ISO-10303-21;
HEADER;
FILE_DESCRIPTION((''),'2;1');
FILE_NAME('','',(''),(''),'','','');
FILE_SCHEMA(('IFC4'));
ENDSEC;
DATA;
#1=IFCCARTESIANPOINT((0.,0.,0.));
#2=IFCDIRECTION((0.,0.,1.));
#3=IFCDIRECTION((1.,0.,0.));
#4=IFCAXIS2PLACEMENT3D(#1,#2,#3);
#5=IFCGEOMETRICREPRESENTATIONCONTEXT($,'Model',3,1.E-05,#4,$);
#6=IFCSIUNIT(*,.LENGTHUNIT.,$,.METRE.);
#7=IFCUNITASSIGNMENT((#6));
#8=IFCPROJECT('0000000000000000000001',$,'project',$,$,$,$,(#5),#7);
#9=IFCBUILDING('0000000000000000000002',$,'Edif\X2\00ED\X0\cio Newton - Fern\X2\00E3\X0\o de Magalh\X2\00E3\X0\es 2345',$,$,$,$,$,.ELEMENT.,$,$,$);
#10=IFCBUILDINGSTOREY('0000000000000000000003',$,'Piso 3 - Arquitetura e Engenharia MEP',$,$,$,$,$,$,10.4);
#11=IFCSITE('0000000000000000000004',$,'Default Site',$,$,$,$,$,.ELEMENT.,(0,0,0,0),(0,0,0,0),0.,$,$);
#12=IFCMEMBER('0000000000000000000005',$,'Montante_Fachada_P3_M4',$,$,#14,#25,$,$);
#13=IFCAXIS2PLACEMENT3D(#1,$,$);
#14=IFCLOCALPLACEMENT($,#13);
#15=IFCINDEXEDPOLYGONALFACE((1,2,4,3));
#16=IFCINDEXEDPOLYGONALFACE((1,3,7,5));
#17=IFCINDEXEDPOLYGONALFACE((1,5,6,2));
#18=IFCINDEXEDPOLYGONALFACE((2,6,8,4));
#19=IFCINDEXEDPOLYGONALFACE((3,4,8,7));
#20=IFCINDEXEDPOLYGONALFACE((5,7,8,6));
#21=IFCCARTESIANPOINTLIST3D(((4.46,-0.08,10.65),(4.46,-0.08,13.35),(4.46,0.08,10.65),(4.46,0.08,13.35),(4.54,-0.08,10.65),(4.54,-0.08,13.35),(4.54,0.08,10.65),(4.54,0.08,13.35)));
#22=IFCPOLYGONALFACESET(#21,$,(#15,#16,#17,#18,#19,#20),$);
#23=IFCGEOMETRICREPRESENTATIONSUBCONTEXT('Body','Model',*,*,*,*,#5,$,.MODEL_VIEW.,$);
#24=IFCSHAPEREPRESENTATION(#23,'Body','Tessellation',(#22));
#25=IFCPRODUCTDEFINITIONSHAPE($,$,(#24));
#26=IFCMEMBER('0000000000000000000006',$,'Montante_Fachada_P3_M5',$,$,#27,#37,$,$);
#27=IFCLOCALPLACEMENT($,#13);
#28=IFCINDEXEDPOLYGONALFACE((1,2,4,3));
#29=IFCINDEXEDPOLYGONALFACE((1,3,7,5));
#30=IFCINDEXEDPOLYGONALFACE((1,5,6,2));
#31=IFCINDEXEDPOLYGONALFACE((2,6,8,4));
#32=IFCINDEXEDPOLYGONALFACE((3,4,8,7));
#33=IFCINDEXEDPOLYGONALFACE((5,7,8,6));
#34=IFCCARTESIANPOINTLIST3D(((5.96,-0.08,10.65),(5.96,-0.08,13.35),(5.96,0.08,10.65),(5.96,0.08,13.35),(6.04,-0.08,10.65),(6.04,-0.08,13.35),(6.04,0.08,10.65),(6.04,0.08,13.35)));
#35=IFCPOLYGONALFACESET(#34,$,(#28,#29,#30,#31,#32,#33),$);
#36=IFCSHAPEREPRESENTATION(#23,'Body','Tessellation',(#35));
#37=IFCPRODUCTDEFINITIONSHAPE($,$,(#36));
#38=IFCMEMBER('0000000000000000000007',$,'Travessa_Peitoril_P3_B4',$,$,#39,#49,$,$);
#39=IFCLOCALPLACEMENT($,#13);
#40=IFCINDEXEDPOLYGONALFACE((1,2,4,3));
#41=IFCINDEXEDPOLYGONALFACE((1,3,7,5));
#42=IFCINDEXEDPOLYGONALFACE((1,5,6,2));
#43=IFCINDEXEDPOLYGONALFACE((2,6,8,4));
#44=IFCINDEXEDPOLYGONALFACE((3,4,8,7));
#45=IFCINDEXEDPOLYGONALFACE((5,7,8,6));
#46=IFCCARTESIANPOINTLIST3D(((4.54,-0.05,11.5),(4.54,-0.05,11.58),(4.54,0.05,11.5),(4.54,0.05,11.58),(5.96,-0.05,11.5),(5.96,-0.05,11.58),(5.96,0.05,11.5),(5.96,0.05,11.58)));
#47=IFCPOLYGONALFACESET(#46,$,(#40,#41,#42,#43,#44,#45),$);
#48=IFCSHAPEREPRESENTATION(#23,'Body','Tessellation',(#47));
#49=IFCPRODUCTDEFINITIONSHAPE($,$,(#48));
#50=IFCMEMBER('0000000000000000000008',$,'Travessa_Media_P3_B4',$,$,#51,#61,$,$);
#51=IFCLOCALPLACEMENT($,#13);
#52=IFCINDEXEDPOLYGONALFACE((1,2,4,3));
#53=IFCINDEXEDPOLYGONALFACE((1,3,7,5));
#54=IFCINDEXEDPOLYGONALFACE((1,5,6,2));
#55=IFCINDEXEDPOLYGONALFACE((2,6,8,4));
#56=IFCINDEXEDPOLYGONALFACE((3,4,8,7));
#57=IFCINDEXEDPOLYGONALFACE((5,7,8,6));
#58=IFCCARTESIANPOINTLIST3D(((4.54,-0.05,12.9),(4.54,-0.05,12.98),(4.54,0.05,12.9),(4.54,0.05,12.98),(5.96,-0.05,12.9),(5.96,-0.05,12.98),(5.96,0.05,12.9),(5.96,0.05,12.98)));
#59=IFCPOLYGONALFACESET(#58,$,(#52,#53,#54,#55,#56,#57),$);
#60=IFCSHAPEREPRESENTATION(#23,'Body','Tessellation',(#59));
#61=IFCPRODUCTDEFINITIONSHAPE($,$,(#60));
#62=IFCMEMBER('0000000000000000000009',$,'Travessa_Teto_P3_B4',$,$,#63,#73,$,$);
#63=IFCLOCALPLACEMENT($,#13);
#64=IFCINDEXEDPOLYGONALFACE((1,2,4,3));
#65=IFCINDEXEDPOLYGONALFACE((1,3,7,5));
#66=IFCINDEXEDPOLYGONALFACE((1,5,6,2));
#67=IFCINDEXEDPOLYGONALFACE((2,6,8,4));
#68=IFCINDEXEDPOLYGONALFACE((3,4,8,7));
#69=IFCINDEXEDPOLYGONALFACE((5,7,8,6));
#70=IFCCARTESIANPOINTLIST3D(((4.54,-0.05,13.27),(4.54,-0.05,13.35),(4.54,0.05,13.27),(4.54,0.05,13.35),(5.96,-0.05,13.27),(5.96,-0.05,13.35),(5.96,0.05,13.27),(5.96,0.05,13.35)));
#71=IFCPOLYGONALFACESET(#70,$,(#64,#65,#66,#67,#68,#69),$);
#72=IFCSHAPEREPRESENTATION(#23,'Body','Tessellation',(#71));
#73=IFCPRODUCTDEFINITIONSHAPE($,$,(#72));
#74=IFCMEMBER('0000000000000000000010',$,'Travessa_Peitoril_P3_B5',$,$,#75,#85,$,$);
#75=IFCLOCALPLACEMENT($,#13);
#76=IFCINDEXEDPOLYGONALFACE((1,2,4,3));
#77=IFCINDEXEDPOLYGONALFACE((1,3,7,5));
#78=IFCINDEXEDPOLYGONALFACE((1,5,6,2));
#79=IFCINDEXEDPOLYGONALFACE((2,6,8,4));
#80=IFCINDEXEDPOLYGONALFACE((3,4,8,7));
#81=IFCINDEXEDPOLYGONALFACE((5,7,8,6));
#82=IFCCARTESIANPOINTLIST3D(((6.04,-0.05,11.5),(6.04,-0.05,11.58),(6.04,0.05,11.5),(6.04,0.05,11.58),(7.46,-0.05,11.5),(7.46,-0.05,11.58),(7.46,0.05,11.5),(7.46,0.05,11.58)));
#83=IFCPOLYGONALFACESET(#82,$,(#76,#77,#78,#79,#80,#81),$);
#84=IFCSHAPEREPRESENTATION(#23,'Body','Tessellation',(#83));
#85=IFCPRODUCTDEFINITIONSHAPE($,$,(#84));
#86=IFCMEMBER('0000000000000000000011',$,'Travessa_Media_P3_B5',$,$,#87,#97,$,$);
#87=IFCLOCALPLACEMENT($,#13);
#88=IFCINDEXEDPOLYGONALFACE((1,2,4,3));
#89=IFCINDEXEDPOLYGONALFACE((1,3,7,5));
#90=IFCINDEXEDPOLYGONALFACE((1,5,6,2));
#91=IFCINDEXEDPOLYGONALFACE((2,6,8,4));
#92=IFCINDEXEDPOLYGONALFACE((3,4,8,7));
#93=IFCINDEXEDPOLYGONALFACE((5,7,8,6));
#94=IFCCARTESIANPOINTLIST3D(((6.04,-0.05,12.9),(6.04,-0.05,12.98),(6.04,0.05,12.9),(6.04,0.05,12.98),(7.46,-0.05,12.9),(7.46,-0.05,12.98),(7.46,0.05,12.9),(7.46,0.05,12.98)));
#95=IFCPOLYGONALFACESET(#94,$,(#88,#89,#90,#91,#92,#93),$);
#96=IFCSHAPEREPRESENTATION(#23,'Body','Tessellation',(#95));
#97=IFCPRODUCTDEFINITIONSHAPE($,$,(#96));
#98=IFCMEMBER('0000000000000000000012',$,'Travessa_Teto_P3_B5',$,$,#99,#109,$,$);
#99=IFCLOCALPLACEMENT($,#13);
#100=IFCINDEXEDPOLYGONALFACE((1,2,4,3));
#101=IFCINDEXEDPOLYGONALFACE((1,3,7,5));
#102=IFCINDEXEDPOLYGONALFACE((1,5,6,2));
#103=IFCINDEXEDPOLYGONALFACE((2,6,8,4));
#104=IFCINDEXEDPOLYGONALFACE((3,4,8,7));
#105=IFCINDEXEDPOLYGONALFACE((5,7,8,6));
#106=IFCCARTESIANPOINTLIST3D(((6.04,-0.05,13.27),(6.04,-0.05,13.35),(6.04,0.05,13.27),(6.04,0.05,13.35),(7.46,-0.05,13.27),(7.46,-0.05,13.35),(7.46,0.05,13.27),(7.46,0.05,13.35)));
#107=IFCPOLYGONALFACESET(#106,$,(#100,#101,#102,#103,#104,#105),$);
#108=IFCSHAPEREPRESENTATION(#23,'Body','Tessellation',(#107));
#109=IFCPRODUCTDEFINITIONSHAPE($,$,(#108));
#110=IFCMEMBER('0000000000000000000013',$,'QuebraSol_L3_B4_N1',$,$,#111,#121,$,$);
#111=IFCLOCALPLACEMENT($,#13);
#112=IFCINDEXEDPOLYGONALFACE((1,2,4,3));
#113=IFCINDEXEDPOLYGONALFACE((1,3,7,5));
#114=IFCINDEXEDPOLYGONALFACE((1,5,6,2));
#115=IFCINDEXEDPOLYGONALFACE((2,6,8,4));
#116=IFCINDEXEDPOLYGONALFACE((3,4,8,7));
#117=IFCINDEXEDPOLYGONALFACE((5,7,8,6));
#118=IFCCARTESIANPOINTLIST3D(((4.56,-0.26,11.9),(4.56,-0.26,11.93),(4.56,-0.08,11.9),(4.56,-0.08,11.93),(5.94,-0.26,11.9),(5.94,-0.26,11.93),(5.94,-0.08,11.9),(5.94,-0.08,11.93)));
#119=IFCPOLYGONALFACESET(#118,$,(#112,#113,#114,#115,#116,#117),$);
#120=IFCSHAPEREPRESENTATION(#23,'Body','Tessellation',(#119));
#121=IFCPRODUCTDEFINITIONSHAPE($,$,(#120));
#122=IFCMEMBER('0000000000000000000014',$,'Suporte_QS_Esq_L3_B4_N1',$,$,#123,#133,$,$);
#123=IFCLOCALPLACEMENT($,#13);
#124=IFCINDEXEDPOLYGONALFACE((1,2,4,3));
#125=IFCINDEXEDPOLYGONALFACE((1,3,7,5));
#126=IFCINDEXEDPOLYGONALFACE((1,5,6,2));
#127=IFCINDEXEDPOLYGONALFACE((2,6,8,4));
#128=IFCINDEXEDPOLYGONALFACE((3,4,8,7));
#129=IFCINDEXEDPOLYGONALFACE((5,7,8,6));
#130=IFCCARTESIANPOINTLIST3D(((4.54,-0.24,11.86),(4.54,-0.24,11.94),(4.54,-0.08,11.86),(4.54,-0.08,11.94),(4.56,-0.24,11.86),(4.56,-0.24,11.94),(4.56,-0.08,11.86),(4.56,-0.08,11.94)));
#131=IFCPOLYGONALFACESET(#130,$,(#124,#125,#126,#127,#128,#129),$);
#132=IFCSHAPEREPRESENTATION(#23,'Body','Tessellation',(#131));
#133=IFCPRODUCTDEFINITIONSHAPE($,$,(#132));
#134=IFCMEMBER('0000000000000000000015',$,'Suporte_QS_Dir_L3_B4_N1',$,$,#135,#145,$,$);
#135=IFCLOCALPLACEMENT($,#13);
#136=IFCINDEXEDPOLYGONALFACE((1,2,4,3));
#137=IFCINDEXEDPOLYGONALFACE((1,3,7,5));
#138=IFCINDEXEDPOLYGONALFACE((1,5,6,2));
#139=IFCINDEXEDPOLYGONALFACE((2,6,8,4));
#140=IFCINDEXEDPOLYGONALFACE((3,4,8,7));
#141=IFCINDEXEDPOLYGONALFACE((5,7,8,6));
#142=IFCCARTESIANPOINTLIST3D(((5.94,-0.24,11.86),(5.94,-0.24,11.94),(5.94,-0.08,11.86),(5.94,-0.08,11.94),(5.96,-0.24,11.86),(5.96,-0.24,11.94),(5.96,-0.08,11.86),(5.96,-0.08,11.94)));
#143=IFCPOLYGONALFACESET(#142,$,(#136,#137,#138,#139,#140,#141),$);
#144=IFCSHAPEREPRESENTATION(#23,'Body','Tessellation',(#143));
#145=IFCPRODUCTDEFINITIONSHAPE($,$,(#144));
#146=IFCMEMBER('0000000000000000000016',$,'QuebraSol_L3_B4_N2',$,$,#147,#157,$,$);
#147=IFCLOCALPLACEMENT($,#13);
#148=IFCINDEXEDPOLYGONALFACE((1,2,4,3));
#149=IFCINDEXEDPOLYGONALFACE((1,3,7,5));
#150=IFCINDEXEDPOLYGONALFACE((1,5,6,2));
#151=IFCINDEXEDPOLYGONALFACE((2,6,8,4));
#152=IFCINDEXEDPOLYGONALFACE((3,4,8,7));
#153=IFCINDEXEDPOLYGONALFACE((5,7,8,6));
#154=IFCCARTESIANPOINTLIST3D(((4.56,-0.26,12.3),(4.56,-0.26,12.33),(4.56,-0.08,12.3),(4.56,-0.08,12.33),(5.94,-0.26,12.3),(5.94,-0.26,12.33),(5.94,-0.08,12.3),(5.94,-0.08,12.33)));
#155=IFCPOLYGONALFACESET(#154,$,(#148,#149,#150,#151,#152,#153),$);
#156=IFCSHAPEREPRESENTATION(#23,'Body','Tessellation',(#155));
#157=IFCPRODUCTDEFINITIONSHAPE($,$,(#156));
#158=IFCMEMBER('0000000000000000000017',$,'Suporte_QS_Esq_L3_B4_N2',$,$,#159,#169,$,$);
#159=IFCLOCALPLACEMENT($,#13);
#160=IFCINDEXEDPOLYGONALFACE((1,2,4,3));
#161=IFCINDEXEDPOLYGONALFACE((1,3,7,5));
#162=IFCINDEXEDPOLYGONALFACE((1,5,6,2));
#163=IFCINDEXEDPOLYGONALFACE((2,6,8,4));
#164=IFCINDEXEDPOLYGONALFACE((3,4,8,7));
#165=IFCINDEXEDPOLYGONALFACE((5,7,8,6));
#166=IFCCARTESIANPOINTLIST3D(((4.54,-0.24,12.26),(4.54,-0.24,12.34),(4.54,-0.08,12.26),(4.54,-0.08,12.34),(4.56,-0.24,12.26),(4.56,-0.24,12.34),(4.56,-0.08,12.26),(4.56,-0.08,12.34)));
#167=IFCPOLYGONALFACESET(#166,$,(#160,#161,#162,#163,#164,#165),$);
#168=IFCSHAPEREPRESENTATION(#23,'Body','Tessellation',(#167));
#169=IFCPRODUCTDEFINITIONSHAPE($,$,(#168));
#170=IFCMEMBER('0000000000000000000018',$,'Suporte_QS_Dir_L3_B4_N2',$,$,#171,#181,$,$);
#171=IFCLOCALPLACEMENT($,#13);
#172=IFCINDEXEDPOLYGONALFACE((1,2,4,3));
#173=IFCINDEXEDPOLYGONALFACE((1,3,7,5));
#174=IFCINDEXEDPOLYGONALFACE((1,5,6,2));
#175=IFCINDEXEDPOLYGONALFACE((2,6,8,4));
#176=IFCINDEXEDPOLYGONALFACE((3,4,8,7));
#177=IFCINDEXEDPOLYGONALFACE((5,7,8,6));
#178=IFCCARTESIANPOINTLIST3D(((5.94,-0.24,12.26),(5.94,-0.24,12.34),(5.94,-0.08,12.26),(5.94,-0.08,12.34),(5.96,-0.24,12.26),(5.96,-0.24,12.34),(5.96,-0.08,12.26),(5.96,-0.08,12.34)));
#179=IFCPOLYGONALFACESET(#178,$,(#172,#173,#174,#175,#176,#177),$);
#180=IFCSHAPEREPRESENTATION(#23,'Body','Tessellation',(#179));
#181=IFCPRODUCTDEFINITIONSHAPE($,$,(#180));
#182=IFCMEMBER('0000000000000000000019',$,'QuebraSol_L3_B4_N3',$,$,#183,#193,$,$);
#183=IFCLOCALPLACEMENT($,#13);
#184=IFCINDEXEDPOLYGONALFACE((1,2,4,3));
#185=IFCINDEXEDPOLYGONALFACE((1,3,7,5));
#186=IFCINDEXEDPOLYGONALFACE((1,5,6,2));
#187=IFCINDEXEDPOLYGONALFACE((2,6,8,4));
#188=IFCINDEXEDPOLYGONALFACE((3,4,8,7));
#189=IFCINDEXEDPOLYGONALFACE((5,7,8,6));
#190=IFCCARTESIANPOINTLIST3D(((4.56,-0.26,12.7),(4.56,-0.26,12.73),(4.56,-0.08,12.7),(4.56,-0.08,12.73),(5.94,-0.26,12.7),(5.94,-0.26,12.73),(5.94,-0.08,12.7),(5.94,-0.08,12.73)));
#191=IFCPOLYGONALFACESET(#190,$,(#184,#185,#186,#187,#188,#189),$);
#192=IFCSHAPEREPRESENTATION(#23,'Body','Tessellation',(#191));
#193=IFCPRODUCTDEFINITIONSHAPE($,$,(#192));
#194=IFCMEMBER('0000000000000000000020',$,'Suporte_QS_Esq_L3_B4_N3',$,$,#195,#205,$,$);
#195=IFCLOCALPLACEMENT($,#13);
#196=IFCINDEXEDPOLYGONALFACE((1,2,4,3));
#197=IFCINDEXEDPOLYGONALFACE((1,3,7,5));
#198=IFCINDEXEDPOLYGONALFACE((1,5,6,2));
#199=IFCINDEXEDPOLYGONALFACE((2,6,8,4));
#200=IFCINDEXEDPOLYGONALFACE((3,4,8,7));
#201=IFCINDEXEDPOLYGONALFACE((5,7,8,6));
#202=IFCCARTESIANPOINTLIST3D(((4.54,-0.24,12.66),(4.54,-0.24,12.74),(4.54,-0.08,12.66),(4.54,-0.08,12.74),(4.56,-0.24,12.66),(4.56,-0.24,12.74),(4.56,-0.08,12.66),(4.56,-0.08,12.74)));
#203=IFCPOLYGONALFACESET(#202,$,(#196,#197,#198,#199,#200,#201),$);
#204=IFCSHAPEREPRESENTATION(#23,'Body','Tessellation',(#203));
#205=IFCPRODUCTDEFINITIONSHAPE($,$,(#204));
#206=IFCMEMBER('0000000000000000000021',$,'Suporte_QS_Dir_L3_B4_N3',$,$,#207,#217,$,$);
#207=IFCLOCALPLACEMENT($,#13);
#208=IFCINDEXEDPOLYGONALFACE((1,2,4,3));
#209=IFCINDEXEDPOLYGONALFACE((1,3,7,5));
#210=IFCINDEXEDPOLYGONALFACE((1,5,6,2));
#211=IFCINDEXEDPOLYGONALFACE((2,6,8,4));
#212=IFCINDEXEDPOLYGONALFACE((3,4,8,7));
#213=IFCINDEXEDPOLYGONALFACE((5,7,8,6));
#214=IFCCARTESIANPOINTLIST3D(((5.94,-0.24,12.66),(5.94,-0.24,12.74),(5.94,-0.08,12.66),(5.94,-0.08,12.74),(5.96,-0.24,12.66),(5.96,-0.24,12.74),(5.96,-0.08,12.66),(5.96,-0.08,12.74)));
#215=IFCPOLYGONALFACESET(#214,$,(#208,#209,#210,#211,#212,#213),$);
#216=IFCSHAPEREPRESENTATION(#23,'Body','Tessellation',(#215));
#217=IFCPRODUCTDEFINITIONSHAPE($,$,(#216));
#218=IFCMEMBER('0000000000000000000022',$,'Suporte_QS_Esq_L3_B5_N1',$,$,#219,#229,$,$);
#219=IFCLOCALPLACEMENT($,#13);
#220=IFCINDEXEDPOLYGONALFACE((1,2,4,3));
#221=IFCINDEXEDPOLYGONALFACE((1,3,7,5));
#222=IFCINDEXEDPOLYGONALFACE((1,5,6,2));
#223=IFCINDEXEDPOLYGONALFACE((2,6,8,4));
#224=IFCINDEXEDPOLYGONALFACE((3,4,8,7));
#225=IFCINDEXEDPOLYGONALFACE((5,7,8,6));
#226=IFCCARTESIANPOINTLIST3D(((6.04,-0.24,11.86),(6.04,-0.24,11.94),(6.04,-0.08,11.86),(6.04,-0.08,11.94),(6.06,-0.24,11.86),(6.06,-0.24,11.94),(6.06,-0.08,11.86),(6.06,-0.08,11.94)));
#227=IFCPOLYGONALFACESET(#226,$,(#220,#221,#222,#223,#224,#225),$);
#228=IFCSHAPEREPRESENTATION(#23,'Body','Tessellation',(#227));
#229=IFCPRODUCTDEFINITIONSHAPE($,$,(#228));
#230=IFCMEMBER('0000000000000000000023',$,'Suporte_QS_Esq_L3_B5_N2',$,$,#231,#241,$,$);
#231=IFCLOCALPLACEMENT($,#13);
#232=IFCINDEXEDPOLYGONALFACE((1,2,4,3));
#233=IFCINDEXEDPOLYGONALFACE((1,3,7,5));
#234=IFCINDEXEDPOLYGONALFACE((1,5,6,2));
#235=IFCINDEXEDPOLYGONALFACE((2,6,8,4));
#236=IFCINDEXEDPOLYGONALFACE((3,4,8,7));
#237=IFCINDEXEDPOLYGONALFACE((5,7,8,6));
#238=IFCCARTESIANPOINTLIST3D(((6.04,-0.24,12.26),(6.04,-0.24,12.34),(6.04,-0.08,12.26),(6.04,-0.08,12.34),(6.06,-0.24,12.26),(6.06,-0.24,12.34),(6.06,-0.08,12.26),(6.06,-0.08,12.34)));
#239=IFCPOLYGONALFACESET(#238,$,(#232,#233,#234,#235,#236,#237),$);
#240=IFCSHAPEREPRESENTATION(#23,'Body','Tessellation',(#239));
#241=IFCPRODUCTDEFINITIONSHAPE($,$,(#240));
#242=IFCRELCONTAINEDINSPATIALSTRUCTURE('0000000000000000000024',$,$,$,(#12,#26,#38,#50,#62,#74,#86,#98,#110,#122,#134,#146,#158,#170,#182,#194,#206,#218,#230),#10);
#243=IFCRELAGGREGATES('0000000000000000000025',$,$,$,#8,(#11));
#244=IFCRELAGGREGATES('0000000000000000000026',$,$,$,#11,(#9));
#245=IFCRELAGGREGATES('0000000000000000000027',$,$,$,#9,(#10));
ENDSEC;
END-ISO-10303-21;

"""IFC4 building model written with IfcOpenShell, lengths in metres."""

from ifc_helpers import new_model, si_unit, frame, frame_2d, origin_with_axes, place, context, subcontext, project, spatial, rectangle, extrude, element, save


model = new_model("IFC4")

# Units and contexts
model_context = context("Model", 3, precision=1e-05, world=origin_with_axes())
body_context = subcontext(model_context, "Body", "Model", "MODEL_VIEW")
ifc_project = project(units=[si_unit("LENGTHUNIT", "METRE")], contexts=[model_context])

# Site, building, storey
site = spatial("IfcSite", under=ifc_project, Name="Default Site", CompositionType="ELEMENT", RefLatitude=(0, 0, 0, 0), RefLongitude=(0, 0, 0, 0), RefElevation=0.0)
building = spatial("IfcBuilding", under=site, Name="Edifício Newton - Fernão de Magalhães 2345", CompositionType="ELEMENT")
storey = spatial("IfcBuildingStorey", under=building, Name="Piso 3 - Arquitetura e Engenharia MEP", Elevation=10.4)

# Members
for number, where, z_axis, x_axis, name in (
    (1, (4.46, -0.08, 10.65), (0.0, 0.0, 1.0), (1.0, 0.0, 0.0), "Montante_Fachada_P3_M4"),
    (2, (5.96, -0.08, 10.65), (0.0, 0.0, 1.0), (1.0, 0.0, 0.0), "Montante_Fachada_P3_M5"),
):
    element("IfcMember", number, at=place(None, frame(where, z_axis=z_axis, x_axis=x_axis)), inside=storey, Name=name, context=body_context, shape_type="SweptSolid", body=[
        extrude(rectangle(XDim=0.08, YDim=0.16, at=frame_2d((0.04, 0.08))), origin_with_axes(), (0.0, 0.0, 1.0), 2.7),
    ])
for number, where, z_axis, x_axis, name in (
    (3, (4.54, -0.05, 11.5), (0.0, 0.0, 1.0), (1.0, 0.0, 0.0), "Travessa_Peitoril_P3_B4"),
    (4, (4.54, -0.05, 12.9), (0.0, 0.0, 1.0), (1.0, 0.0, 0.0), "Travessa_Media_P3_B4"),
    (5, (4.54, -0.05, 13.27), (0.0, 0.0, 1.0), (1.0, 0.0, 0.0), "Travessa_Teto_P3_B4"),
    (6, (6.04, -0.05, 11.5), (0.0, 0.0, 1.0), (1.0, 0.0, 0.0), "Travessa_Peitoril_P3_B5"),
    (7, (6.04, -0.05, 12.9), (0.0, 0.0, 1.0), (1.0, 0.0, 0.0), "Travessa_Media_P3_B5"),
    (8, (6.04, -0.05, 13.27), (0.0, 0.0, 1.0), (1.0, 0.0, 0.0), "Travessa_Teto_P3_B5"),
):
    element("IfcMember", number, at=place(None, frame(where, z_axis=z_axis, x_axis=x_axis)), inside=storey, Name=name, context=body_context, shape_type="SweptSolid", body=[
        extrude(rectangle(XDim=1.42, YDim=0.1, at=frame_2d((0.71, 0.05))), origin_with_axes(), (0.0, 0.0, 1.0), 0.08),
    ])
member_1_placement = place(None, frame((4.56, -0.26, 11.9), z_axis=(0.0, 0.0, 1.0), x_axis=(1.0, 0.0, 0.0)))
element("IfcMember", 9, at=member_1_placement, inside=storey, Name="QuebraSol_L3_B4_N1", context=body_context, shape_type="SweptSolid", body=[
    extrude(rectangle(XDim=1.38, YDim=0.18, at=frame_2d((0.69, 0.09))), origin_with_axes(), (0.0, 0.0, 1.0), 0.03),
])
for number, where, z_axis, x_axis, name in (
    (10, (4.54, -0.24, 11.86), (0.0, 0.0, 1.0), (1.0, 0.0, 0.0), "Suporte_QS_Esq_L3_B4_N1"),
    (11, (5.94, -0.24, 11.86), (0.0, 0.0, 1.0), (1.0, 0.0, 0.0), "Suporte_QS_Dir_L3_B4_N1"),
):
    element("IfcMember", number, at=place(None, frame(where, z_axis=z_axis, x_axis=x_axis)), inside=storey, Name=name, context=body_context, shape_type="SweptSolid", body=[
        extrude(rectangle(XDim=0.02, YDim=0.16, at=frame_2d((0.01, 0.08))), origin_with_axes(), (0.0, 0.0, 1.0), 0.08),
    ])
member_2_placement = place(None, frame((4.56, -0.26, 12.3), z_axis=(0.0, 0.0, 1.0), x_axis=(1.0, 0.0, 0.0)))
element("IfcMember", 12, at=member_2_placement, inside=storey, Name="QuebraSol_L3_B4_N2", context=body_context, shape_type="SweptSolid", body=[
    extrude(rectangle(XDim=1.38, YDim=0.18, at=frame_2d((0.69, 0.09))), origin_with_axes(), (0.0, 0.0, 1.0), 0.03),
])
for number, where, z_axis, x_axis, name in (
    (13, (4.54, -0.24, 12.26), (0.0, 0.0, 1.0), (1.0, 0.0, 0.0), "Suporte_QS_Esq_L3_B4_N2"),
    (14, (5.94, -0.24, 12.26), (0.0, 0.0, 1.0), (1.0, 0.0, 0.0), "Suporte_QS_Dir_L3_B4_N2"),
):
    element("IfcMember", number, at=place(None, frame(where, z_axis=z_axis, x_axis=x_axis)), inside=storey, Name=name, context=body_context, shape_type="SweptSolid", body=[
        extrude(rectangle(XDim=0.02, YDim=0.16, at=frame_2d((0.01, 0.08))), origin_with_axes(), (0.0, 0.0, 1.0), 0.08),
    ])
member_3_placement = place(None, frame((4.56, -0.26, 12.7), z_axis=(0.0, 0.0, 1.0), x_axis=(1.0, 0.0, 0.0)))
element("IfcMember", 15, at=member_3_placement, inside=storey, Name="QuebraSol_L3_B4_N3", context=body_context, shape_type="SweptSolid", body=[
    extrude(rectangle(XDim=1.38, YDim=0.18, at=frame_2d((0.69, 0.09))), origin_with_axes(), (0.0, 0.0, 1.0), 0.03),
])
for number, where, z_axis, x_axis, name in (
    (16, (4.54, -0.24, 12.66), (0.0, 0.0, 1.0), (1.0, 0.0, 0.0), "Suporte_QS_Esq_L3_B4_N3"),
    (17, (5.94, -0.24, 12.66), (0.0, 0.0, 1.0), (1.0, 0.0, 0.0), "Suporte_QS_Dir_L3_B4_N3"),
    (18, (6.04, -0.24, 11.86), (0.0, 0.0, 1.0), (1.0, 0.0, 0.0), "Suporte_QS_Esq_L3_B5_N1"),
    (19, (6.04, -0.24, 12.26), (0.0, 0.0, 1.0), (1.0, 0.0, 0.0), "Suporte_QS_Esq_L3_B5_N2"),
):
    element("IfcMember", number, at=place(None, frame(where, z_axis=z_axis, x_axis=x_axis)), inside=storey, Name=name, context=body_context, shape_type="SweptSolid", body=[
        extrude(rectangle(XDim=0.02, YDim=0.16, at=frame_2d((0.01, 0.08))), origin_with_axes(), (0.0, 0.0, 1.0), 0.08),
    ])

save(model, "model.ifc")
